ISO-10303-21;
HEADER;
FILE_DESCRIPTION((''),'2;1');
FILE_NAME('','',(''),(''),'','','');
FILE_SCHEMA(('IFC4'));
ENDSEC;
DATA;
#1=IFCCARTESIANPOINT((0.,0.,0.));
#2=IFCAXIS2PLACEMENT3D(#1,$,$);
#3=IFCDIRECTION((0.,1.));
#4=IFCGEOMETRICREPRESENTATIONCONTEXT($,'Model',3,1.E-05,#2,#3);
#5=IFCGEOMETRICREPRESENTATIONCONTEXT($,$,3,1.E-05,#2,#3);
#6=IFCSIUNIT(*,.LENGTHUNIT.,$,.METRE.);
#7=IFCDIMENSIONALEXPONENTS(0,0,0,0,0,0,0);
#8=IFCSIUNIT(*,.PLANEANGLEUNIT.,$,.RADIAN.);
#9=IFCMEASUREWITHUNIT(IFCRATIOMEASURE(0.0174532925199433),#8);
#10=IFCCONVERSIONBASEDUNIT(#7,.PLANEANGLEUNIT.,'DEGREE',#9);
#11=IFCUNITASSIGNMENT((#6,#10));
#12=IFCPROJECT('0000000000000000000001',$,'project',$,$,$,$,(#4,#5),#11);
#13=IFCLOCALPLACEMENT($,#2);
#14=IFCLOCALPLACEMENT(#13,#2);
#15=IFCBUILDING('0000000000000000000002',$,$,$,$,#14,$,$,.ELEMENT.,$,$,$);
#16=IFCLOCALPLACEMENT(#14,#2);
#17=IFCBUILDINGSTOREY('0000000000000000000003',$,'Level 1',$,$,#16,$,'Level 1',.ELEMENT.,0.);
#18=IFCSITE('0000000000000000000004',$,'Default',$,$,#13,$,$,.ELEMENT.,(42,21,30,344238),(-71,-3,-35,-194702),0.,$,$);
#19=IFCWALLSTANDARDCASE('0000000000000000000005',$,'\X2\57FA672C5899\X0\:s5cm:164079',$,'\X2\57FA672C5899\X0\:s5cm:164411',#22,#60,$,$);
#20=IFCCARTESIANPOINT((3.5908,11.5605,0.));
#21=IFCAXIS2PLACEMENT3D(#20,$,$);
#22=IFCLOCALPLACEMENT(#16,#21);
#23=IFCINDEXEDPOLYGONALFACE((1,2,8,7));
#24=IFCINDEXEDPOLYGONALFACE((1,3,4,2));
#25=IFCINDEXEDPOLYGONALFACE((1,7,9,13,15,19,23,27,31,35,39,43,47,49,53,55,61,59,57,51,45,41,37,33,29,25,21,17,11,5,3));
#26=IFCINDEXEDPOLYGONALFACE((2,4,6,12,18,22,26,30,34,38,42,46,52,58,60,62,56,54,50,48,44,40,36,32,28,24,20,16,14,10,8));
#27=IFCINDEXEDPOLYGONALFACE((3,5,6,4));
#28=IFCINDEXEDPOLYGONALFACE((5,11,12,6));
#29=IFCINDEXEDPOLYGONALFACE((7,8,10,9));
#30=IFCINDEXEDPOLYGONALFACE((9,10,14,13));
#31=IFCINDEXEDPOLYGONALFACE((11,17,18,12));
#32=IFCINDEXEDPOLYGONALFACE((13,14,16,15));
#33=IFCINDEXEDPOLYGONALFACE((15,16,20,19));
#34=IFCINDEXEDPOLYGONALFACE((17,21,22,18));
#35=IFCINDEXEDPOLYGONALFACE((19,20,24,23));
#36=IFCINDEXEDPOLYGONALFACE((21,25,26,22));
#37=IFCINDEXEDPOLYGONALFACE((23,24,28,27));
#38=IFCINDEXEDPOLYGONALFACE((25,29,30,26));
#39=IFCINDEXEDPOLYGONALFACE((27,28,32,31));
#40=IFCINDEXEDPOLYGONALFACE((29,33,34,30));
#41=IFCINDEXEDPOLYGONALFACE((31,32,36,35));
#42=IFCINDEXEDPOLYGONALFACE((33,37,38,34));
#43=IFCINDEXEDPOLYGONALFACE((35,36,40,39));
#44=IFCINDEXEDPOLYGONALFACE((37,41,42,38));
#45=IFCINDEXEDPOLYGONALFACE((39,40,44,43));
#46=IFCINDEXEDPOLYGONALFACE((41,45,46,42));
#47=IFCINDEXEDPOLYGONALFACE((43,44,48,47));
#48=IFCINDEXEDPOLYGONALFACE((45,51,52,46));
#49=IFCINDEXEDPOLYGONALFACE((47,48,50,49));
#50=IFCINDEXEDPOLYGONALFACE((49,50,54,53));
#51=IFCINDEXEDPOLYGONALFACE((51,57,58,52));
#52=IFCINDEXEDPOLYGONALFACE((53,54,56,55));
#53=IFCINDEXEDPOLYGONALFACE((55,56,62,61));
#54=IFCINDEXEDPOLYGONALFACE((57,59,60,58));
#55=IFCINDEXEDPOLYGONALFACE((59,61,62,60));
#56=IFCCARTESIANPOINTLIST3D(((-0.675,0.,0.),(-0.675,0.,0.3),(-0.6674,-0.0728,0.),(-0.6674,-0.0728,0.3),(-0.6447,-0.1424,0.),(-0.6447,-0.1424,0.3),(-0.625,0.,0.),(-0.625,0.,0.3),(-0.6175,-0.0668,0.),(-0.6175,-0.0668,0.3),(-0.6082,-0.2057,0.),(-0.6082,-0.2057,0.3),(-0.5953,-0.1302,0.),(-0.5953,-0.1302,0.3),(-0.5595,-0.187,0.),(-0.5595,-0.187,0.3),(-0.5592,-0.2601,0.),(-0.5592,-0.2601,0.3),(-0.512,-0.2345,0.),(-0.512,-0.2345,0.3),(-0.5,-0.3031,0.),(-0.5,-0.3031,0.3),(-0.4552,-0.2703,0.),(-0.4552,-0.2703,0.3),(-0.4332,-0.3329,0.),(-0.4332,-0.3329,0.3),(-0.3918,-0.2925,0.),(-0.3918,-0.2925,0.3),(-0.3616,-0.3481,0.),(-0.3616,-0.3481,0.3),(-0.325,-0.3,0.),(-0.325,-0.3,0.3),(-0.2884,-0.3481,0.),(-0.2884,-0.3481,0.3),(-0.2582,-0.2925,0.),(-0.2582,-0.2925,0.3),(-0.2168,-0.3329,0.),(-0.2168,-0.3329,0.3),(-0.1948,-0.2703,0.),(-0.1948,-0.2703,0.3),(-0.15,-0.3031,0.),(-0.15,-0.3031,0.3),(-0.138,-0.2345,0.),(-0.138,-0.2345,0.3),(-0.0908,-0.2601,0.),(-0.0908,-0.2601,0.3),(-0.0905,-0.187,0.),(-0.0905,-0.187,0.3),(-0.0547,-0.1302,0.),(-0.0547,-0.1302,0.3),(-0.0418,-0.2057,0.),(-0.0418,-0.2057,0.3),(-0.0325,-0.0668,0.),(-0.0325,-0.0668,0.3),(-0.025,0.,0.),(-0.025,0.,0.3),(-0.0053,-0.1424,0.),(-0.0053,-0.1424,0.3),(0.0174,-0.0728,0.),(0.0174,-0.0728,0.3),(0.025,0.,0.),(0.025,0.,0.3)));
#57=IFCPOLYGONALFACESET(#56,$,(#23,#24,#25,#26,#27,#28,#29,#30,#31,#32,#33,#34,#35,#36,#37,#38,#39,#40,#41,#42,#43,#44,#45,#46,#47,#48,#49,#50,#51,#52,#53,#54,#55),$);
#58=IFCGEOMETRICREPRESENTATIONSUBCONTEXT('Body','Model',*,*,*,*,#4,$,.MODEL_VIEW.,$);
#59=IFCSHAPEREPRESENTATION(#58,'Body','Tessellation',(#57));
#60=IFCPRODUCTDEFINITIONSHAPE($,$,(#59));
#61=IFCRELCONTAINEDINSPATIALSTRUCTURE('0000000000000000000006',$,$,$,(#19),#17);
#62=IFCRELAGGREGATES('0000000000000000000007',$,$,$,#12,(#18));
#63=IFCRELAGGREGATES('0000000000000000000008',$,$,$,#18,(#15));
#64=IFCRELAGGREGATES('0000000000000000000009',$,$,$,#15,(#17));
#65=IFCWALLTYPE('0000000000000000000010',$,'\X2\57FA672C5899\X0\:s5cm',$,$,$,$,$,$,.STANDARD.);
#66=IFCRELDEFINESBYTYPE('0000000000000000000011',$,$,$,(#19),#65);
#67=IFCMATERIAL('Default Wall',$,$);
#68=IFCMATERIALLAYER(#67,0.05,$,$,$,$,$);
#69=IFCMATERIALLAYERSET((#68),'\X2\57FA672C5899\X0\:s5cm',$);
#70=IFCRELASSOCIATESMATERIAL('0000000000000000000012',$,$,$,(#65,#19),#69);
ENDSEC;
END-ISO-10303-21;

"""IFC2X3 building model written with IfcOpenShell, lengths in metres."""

from ifc_helpers import new_model, entity, si_unit, converted_unit, direction, frame, frame_2d, origin, place, context, subcontext, project, spatial, polyline, circle_curve, parameter, trimmed, segment, composite_curve, outline, extrude, material, layer, layer_set, layer_usage, type_object, element, save


model = new_model("IFC2X3")

# Units and contexts
model_context = context("Model", 3, precision=1e-05, world=origin(), true_north=direction((0.0, 1.0)))
context_of_model = context(None, 3, precision=1e-05, world=origin(), true_north=direction((0.0, 1.0)))
body_context = subcontext(model_context, "Body", "Model", "MODEL_VIEW")
ifc_project = project(units=[si_unit("LENGTHUNIT", "METRE"), converted_unit("PLANEANGLEUNIT", "DEGREE", entity("IfcRatioMeasure", 0.0174532925199433), si_unit("PLANEANGLEUNIT", "RADIAN"), dimensions=[0, 0, 0, 0, 0, 0, 0])], contexts=[model_context, context_of_model])

# Site, building, storey
site_placement = place(None, origin())
site = spatial("IfcSite", under=ifc_project, at=site_placement, Name="Default", CompositionType="ELEMENT", RefLatitude=(42, 21, 30, 344238), RefLongitude=(-71, -3, -35, -194702), RefElevation=0.0)
building_placement = place(site_placement, origin())
building = spatial("IfcBuilding", under=site, at=building_placement, CompositionType="ELEMENT")
storey_placement = place(building_placement, origin())
storey = spatial("IfcBuildingStorey", under=building, at=storey_placement, Name="Level 1", LongName="Level 1", CompositionType="ELEMENT", Elevation=0.0)

# Wall
ifc_material = material(Name="Default Wall")
ifc_layer = layer(ifc_material, 0.05)
ifc_layer_set = layer_set([ifc_layer], Name="基本墙:s5cm")
ifc_layer_usage_1 = layer_usage(ifc_layer_set, "AXIS2", "POSITIVE", -0.025)
wall_type = type_object("IfcWallType", Name="基本墙:s5cm", PredefinedType="STANDARD", material=ifc_layer_set)
wall_1_placement = place(storey_placement, frame((3.5908, 11.5605, 0.0)))
element("IfcWallStandardCase", 1, at=wall_1_placement, inside=storey, type_object=wall_type, material=ifc_layer_usage_1, Name="基本墙:s5cm:164079", ObjectType="基本墙:s5cm:164411", context=body_context, shape_type="SweptSolid", body=[
    extrude(outline(composite_curve([segment(trimmed(circle_curve(frame_2d((-0.325, 0.0), x_axis=(1.0, 0.0)), 0.35), [parameter(180.0)], [parameter(0.0)], True, "PARAMETER"), True, "CONTINUOUS"), segment(polyline([(0.025, 0.0), (-0.025, 0.0)]), True, "CONTINUOUS"), segment(trimmed(circle_curve(frame_2d((-0.325, 0.0), x_axis=(1.0, 0.0)), 0.3), [parameter(180.0)], [parameter(0.0)], True, "PARAMETER"), False, "CONTINUOUS"), segment(polyline([(-0.625, 0.0), (-0.675, 0.0)]), True, "CONTINUOUS")], self_intersect=False)), origin(), (0.0, 0.0, 1.0), 0.3),
])

save(model, "model.ifc")
